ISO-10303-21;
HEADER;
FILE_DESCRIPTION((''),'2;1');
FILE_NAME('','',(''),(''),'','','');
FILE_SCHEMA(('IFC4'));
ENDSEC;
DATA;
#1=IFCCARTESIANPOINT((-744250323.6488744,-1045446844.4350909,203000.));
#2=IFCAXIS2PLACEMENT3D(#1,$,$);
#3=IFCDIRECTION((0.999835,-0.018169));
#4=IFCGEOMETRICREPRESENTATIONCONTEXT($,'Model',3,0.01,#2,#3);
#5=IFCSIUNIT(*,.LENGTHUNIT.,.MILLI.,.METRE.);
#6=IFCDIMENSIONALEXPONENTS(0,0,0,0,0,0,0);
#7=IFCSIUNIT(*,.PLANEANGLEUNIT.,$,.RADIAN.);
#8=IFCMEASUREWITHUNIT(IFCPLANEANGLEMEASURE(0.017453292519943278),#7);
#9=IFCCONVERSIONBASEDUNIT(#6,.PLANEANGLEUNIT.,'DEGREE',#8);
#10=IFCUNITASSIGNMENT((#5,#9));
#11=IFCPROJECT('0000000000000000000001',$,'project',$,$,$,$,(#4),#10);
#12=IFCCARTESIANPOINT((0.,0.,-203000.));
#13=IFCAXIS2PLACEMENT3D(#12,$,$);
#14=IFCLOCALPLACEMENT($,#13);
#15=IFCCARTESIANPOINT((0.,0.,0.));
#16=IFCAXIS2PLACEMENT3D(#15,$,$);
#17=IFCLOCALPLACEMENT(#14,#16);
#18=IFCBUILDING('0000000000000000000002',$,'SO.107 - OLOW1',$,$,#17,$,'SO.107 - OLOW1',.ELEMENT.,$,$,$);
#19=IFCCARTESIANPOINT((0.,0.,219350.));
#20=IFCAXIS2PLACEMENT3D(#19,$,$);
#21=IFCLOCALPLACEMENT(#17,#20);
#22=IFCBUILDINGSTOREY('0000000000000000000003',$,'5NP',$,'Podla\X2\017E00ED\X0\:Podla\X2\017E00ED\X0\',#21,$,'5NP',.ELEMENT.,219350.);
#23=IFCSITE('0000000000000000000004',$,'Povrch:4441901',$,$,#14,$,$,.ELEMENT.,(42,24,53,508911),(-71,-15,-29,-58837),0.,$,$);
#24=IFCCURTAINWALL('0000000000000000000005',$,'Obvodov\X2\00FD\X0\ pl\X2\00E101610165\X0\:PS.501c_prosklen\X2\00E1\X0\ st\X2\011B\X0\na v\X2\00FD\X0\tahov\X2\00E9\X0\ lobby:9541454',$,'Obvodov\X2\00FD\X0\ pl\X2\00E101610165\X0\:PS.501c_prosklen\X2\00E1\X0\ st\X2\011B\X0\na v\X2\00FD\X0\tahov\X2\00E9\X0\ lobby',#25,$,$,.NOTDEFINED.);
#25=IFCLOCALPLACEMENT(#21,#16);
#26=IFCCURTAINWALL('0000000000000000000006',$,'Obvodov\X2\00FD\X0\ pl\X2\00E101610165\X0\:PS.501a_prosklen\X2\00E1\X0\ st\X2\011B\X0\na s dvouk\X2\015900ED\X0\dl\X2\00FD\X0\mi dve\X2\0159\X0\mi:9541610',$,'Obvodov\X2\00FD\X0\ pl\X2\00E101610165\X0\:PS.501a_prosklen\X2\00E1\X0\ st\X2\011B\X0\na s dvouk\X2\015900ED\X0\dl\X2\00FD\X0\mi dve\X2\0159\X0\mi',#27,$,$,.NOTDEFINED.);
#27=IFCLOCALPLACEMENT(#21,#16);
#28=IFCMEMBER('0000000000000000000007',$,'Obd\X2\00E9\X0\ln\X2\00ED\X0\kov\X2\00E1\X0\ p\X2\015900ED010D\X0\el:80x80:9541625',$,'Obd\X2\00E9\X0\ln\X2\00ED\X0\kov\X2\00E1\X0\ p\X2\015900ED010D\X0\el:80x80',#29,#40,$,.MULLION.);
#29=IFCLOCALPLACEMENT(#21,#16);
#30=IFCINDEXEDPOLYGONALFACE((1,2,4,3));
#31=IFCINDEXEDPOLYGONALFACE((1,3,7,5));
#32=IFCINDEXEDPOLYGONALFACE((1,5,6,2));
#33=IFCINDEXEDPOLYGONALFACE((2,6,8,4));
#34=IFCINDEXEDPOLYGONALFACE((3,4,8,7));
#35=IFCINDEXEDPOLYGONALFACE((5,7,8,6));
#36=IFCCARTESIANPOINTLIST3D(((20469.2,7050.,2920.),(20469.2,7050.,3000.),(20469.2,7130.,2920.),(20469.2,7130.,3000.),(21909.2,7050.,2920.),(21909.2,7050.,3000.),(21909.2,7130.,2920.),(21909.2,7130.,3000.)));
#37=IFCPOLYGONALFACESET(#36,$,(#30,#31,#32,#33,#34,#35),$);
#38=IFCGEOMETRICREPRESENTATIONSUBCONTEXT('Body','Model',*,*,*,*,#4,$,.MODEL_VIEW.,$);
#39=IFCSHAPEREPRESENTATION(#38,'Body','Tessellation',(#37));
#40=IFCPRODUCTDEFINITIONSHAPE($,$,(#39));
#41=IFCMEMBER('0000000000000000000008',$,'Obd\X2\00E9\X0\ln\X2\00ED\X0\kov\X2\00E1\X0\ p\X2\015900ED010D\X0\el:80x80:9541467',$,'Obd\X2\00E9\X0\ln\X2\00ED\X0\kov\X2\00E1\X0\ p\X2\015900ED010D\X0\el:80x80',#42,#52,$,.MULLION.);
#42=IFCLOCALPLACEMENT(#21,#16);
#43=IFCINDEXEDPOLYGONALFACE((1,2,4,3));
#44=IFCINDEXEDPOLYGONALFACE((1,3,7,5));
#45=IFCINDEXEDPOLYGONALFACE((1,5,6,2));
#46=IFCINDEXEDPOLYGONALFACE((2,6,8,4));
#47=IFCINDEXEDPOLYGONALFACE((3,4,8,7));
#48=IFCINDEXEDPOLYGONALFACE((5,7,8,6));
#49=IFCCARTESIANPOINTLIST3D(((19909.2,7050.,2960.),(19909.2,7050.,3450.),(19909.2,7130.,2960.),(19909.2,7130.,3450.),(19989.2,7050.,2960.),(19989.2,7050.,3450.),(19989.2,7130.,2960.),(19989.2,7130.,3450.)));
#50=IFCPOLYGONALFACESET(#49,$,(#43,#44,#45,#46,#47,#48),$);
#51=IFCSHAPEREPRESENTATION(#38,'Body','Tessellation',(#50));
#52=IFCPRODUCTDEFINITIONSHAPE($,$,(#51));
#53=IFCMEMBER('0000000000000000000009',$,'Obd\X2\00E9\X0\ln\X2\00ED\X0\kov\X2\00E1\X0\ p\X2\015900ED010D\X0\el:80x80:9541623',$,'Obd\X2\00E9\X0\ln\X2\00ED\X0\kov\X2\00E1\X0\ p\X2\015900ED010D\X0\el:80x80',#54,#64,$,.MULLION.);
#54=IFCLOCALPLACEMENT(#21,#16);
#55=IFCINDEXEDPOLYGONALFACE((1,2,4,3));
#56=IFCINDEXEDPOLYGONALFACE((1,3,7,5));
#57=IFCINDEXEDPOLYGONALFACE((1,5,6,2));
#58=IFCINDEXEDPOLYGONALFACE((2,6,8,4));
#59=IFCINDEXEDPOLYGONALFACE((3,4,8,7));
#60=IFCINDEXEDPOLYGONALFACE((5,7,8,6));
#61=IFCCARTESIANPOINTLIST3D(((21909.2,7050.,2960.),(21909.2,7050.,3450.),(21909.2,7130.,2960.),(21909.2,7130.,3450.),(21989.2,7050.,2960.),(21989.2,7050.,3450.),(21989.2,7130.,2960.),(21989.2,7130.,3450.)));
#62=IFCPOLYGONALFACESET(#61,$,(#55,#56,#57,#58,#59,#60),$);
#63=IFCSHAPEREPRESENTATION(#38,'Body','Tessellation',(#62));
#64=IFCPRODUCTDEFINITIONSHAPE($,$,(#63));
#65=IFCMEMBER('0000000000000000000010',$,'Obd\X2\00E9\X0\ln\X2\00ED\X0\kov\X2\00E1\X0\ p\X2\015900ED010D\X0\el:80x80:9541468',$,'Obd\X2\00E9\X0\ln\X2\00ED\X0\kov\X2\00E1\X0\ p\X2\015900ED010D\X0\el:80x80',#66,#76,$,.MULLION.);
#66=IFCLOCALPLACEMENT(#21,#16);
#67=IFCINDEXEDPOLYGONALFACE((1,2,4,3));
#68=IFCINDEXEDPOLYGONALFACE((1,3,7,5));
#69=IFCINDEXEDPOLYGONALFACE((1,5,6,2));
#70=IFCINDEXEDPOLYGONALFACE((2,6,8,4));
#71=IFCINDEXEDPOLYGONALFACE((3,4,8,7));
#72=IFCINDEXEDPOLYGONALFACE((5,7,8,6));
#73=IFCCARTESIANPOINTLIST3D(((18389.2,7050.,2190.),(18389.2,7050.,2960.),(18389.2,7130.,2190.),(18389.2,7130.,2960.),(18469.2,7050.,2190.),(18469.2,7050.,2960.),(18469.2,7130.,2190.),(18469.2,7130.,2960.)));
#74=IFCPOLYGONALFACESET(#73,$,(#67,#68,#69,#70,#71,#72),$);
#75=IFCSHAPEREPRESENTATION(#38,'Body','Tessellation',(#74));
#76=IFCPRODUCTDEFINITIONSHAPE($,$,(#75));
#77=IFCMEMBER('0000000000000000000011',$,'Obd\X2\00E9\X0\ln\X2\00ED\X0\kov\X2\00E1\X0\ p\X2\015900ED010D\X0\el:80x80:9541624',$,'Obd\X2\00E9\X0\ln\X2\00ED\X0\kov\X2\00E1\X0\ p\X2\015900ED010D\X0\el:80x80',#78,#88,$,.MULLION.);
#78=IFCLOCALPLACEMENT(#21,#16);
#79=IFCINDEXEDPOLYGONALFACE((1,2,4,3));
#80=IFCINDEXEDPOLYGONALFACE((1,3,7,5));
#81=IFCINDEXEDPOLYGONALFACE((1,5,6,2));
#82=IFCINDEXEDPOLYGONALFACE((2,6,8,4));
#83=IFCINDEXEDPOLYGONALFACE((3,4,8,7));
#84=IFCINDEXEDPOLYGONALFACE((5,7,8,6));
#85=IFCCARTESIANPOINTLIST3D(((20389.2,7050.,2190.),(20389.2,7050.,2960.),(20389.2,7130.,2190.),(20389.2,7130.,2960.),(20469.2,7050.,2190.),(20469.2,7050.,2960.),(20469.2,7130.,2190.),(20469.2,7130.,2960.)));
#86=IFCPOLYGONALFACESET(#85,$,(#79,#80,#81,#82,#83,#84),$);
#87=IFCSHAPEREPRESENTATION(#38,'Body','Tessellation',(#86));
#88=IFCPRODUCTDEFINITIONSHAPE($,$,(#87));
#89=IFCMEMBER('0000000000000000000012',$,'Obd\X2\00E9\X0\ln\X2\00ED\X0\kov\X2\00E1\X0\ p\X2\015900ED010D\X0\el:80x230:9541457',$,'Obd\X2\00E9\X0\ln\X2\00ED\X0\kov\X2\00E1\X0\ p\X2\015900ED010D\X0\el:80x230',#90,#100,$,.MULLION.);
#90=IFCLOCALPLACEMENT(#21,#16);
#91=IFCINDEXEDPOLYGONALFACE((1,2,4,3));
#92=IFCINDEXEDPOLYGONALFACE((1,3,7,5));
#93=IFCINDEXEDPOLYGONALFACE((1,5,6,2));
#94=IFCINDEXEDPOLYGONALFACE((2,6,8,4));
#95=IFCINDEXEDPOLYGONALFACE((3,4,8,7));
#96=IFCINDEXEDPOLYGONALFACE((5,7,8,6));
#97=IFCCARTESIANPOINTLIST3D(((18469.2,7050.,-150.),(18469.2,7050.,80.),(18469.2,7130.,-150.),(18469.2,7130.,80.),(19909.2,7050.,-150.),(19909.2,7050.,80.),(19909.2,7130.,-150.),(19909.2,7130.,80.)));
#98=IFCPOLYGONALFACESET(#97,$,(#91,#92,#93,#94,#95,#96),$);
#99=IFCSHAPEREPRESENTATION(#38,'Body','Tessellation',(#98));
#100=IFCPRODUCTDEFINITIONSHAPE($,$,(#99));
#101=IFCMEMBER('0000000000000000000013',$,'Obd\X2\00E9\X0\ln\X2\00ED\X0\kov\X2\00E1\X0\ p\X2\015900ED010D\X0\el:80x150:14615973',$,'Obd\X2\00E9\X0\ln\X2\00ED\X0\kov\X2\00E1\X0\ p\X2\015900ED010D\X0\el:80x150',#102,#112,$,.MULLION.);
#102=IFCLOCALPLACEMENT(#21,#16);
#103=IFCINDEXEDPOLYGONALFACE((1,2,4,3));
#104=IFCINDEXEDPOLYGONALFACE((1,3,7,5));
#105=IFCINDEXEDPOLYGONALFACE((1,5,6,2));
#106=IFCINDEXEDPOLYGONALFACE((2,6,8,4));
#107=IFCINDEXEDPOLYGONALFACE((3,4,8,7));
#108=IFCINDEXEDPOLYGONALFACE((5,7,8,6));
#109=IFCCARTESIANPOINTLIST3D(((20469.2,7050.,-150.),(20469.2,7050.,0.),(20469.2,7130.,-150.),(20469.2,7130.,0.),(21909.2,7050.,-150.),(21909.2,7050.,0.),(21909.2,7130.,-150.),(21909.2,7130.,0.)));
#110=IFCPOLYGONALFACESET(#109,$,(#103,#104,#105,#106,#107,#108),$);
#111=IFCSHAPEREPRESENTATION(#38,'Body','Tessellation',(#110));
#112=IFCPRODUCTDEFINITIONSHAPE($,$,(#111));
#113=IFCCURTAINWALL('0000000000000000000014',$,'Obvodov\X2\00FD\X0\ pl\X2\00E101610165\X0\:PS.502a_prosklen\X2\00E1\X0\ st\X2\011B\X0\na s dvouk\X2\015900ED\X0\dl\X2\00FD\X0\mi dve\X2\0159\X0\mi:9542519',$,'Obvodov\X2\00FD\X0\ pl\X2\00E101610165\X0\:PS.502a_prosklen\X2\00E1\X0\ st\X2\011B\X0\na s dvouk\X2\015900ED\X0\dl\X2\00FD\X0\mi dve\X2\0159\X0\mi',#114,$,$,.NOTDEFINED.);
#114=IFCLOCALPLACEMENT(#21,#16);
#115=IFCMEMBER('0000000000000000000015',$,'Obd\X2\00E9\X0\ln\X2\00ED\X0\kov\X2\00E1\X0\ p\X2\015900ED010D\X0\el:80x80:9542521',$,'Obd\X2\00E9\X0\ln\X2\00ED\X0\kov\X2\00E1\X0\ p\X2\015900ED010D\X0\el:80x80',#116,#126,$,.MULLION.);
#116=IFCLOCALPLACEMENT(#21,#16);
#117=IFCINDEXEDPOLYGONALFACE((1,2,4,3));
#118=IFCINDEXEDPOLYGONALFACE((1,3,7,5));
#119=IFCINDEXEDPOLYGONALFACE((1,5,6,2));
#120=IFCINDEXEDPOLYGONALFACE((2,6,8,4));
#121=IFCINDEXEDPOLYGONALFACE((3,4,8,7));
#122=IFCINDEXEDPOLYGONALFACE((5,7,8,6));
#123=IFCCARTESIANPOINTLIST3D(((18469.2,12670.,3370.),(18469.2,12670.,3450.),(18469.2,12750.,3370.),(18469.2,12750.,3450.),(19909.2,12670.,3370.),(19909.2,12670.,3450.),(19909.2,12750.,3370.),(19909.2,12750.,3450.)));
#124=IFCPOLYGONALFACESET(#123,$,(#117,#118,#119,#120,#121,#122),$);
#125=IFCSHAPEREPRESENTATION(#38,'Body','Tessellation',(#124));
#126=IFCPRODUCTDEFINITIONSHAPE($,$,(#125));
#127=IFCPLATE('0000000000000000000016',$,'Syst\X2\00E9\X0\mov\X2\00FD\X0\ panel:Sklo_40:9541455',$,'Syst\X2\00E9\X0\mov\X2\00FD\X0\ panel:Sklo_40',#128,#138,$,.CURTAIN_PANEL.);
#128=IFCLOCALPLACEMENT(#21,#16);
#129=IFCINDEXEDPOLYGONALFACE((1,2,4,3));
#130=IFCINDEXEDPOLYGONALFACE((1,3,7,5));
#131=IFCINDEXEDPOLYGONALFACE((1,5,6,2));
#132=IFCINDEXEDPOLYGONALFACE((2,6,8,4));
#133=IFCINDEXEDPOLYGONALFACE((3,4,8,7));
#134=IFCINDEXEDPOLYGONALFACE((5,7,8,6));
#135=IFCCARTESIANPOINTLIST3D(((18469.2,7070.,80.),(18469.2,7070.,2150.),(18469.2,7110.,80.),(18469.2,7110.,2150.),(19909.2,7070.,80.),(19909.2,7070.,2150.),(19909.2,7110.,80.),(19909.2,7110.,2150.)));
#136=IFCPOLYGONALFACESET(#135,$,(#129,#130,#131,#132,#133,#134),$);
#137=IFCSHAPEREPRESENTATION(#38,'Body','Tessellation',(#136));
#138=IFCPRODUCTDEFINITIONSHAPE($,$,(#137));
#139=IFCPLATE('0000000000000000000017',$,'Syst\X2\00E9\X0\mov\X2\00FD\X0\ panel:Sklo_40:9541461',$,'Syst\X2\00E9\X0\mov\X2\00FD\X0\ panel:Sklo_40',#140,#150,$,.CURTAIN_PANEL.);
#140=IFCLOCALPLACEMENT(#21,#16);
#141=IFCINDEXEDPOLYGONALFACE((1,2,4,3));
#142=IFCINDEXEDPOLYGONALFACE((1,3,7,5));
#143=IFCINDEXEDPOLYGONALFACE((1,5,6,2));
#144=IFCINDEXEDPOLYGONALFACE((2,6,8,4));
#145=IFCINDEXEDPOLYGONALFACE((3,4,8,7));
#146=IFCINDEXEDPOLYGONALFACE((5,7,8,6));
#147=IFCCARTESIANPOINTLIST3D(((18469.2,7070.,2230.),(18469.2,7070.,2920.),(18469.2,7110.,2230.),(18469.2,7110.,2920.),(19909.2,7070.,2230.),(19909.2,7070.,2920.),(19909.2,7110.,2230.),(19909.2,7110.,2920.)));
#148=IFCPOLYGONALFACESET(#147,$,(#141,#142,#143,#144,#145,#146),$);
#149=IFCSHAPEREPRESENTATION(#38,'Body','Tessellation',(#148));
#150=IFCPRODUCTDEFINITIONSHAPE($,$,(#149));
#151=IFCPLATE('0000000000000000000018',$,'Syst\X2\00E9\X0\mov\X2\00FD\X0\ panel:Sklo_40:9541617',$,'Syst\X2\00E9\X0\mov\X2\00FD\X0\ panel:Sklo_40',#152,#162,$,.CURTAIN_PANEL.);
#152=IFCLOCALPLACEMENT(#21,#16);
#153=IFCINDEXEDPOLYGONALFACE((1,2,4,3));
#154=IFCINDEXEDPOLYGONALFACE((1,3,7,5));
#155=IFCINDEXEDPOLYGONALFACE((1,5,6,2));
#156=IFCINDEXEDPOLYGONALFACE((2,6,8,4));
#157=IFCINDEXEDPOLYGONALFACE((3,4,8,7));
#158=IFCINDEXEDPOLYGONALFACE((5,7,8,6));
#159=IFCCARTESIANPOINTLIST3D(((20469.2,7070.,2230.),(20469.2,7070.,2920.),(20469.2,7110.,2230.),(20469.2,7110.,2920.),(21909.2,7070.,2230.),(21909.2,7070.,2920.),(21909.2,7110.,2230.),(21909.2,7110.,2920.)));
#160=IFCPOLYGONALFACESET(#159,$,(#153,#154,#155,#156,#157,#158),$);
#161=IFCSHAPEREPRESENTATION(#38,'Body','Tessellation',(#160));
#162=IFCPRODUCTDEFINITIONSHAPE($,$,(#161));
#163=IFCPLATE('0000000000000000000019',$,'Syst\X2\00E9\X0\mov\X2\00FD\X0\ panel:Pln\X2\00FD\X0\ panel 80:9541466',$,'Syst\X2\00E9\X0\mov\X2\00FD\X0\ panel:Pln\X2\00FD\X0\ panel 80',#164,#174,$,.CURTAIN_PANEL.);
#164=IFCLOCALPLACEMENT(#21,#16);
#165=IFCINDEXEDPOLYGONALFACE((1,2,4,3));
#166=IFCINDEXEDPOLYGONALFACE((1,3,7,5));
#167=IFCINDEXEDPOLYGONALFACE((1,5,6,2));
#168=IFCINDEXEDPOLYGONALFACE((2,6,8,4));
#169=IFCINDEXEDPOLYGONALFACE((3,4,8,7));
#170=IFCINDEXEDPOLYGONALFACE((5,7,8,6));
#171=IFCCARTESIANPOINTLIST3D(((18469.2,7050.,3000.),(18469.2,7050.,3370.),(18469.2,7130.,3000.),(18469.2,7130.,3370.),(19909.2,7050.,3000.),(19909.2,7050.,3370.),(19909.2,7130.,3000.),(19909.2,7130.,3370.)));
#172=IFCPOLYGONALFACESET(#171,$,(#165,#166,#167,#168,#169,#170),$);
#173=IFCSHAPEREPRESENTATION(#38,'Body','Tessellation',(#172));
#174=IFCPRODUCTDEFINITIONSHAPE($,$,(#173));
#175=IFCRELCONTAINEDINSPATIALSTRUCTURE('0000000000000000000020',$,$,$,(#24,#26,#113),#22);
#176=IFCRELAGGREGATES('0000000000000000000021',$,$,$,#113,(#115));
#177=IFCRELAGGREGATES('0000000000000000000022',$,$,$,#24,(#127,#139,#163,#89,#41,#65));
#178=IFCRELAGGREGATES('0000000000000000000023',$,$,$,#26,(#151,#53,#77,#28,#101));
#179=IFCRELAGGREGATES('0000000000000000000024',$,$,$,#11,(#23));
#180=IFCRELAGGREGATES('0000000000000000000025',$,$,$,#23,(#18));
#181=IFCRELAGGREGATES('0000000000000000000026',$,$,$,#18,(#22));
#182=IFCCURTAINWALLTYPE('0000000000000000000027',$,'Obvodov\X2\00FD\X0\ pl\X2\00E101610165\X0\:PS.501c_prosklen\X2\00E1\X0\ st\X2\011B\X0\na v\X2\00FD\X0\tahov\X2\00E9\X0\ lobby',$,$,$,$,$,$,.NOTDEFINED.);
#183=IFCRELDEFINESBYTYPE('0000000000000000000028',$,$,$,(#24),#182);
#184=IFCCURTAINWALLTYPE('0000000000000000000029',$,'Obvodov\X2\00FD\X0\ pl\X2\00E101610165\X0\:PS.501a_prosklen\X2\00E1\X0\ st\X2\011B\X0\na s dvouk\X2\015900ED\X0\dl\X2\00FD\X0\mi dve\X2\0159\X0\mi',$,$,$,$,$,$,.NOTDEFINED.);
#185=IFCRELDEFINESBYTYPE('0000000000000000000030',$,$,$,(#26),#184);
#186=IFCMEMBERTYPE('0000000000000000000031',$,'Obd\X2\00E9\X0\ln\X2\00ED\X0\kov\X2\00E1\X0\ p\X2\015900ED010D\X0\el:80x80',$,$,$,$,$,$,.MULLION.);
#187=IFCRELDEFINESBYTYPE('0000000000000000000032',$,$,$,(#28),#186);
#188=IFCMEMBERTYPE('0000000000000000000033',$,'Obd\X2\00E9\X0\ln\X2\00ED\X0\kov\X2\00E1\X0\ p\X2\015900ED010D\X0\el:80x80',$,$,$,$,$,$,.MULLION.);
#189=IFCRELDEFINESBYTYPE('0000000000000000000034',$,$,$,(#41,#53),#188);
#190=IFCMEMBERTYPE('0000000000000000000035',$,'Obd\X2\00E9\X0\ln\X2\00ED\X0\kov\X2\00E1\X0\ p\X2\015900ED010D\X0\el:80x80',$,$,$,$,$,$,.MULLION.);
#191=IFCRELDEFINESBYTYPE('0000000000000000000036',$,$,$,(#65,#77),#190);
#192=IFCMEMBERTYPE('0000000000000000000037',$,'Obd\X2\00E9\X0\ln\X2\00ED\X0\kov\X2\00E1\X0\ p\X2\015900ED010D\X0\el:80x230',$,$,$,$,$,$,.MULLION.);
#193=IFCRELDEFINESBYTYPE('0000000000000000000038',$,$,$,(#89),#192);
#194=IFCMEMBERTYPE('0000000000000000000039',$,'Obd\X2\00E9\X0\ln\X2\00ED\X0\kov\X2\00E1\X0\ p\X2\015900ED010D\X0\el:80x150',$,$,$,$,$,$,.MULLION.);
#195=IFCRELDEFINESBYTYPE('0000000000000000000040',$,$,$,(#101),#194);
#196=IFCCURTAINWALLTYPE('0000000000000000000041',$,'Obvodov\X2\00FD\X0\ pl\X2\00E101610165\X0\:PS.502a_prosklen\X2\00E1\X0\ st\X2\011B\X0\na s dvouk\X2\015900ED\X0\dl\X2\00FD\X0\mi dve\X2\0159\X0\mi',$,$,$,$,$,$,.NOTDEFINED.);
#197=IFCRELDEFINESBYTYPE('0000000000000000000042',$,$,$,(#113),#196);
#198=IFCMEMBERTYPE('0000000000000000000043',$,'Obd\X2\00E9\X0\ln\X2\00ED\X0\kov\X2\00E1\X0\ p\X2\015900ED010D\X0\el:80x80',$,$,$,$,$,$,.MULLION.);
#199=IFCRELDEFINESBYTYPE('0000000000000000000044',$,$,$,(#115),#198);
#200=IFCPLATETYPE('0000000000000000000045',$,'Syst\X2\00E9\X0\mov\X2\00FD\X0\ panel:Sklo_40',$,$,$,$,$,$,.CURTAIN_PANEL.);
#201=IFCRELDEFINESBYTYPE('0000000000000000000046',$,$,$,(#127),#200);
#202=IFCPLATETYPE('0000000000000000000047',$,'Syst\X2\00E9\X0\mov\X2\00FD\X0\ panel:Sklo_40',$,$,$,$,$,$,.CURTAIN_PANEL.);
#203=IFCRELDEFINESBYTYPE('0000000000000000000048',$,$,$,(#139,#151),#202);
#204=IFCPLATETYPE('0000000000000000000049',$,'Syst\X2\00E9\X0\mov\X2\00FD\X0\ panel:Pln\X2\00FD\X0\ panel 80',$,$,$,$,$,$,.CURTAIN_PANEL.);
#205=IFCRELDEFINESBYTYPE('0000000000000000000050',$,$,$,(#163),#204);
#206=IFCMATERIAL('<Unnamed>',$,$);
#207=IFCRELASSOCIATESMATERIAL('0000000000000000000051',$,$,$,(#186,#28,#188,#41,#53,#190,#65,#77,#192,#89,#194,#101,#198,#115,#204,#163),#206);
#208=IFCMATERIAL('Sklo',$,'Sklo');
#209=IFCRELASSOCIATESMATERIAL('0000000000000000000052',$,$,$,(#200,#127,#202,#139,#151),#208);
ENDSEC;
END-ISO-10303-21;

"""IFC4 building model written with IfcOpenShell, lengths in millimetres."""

from ifc_helpers import new_model, entity, si_unit, converted_unit, direction, frame, origin, place, context, subcontext, project, spatial, indexed_curve, outline, extrude, source, transform, mapped, material, type_object, type_shapes, element, aggregate, save


model = new_model("IFC4")

# Units and contexts
model_context = context("Model", 3, precision=0.01, world=frame((-744250323.6488744, -1045446844.4350909, 203000.0)), true_north=direction((0.999835, -0.018169)))
body_context = subcontext(model_context, "Body", "Model", "MODEL_VIEW")
ifc_project = project(units=[si_unit("LENGTHUNIT", "METRE", prefix="MILLI"), converted_unit("PLANEANGLEUNIT", "DEGREE", entity("IfcPlaneAngleMeasure", 0.017453292519943278), si_unit("PLANEANGLEUNIT", "RADIAN"), dimensions=[0, 0, 0, 0, 0, 0, 0])], contexts=[model_context])

# Site, building, storey
site_placement = place(None, frame((0.0, 0.0, -203000.0)))
site = spatial("IfcSite", under=ifc_project, at=site_placement, Name="Povrch:4441901", CompositionType="ELEMENT", RefLatitude=(42, 24, 53, 508911), RefLongitude=(-71, -15, -29, -58837), RefElevation=0.0)
building_placement = place(site_placement, origin())
building = spatial("IfcBuilding", under=site, at=building_placement, Name="SO.107 - OLOW1", LongName="SO.107 - OLOW1", CompositionType="ELEMENT")
storey_placement = place(building_placement, frame((0.0, 0.0, 219350.0)))
storey = spatial("IfcBuildingStorey", under=building, at=storey_placement, Name="5NP", ObjectType="Podlaží:Podlaží", LongName="5NP", CompositionType="ELEMENT", Elevation=219350.0)

# Curtain walls
curtain_wall_type_1 = type_object("IfcCurtainWallType", Name="Obvodový plášť:PS.501c_prosklená stěna výtahové lobby", PredefinedType="NOTDEFINED")
curtain_wall_1_placement = place(storey_placement, frame((0.0, 0.0, -219350.0)))
curtain_wall_1 = element("IfcCurtainWall", 1, at=curtain_wall_1_placement, inside=storey, type_object=curtain_wall_type_1, Name="Obvodový plášť:PS.501c_prosklená stěna výtahové lobby:9541454", ObjectType="Obvodový plášť:PS.501c_prosklená stěna výtahové lobby", PredefinedType="NOTDEFINED")
ifc_material_1 = material(Name="<Unnamed>")
curtain_wall_type_2 = type_object("IfcCurtainWallType", Name="Obvodový plášť:PS.501a_prosklená stěna s dvoukřídlými dveřmi", PredefinedType="NOTDEFINED")
curtain_wall_2_placement = place(storey_placement, frame((0.0, 0.0, -219350.0)))
curtain_wall_2 = element("IfcCurtainWall", 2, at=curtain_wall_2_placement, inside=storey, type_object=curtain_wall_type_2, Name="Obvodový plášť:PS.501a_prosklená stěna s dvoukřídlými dveřmi:9541610", ObjectType="Obvodový plášť:PS.501a_prosklená stěna s dvoukřídlými dveřmi", PredefinedType="NOTDEFINED")

# Members
member_type_1 = type_object("IfcMemberType", Name="Obdélníková příčel:80x80", PredefinedType="MULLION", material=ifc_material_1)
shared_shape_1 = source(origin(), body_context, "Body", "SweptSolid", [
    extrude(outline(indexed_curve([(-40.0, -40.0), (40.0, -40.0), (40.0, 40.0), (-40.0, 40.0), (-40.0, -40.0)], self_intersect=False)), frame((0.0, 0.0, -1440.0), z_axis=(0.0, 0.0, 1.0), x_axis=(-1.0, 0.0, 0.0)), (0.0, 0.0, 1.0), 1440.0),
])
type_shapes(member_type_1, [shared_shape_1])
member_1_placement = place(curtain_wall_2_placement, frame((21909.2, 7090.0, 222310.0), z_axis=(1.0, 0.0, 0.0), x_axis=(0.0, 0.0, 1.0)))
member_1 = element("IfcMember", 3, at=member_1_placement, type_object=member_type_1, material=ifc_material_1, Name="Obdélníková příčel:80x80:9541625", ObjectType="Obdélníková příčel:80x80", PredefinedType="MULLION", context=body_context, shape_type="MappedRepresentation", body=[
    mapped(shared_shape_1, transform((0.0, 0.0, 0.0), scale=1.0)),
])
member_type_2 = type_object("IfcMemberType", Name="Obdélníková příčel:80x80", PredefinedType="MULLION", material=ifc_material_1)
shared_shape_2 = source(origin(), body_context, "Body", "SweptSolid", [
    extrude(outline(indexed_curve([(-40.0, -40.0), (40.0, -40.0), (40.0, 40.0), (-40.0, 40.0), (-40.0, -40.0)], self_intersect=False)), frame((-40.0, 0.0, -490.0), z_axis=(0.0, 0.0, 1.0), x_axis=(-1.0, 0.0, 0.0)), (0.0, 0.0, 1.0), 490.0),
])
type_shapes(member_type_2, [shared_shape_2])
member_2_placement = place(curtain_wall_1_placement, frame((19989.2, 7090.0, 222310.0), z_axis=(0.0, 0.0, -1.0), x_axis=(1.0, 0.0, 0.0)))
member_2 = element("IfcMember", 4, at=member_2_placement, type_object=member_type_2, material=ifc_material_1, Name="Obdélníková příčel:80x80:9541467", ObjectType="Obdélníková příčel:80x80", PredefinedType="MULLION", context=body_context, shape_type="MappedRepresentation", body=[
    mapped(shared_shape_2, transform((0.0, 0.0, 0.0), scale=1.0)),
])
member_3_placement = place(curtain_wall_2_placement, frame((21989.2, 7090.0, 222310.0), z_axis=(0.0, 0.0, -1.0), x_axis=(1.0, 0.0, 0.0)))
member_3 = element("IfcMember", 5, at=member_3_placement, type_object=member_type_2, material=ifc_material_1, Name="Obdélníková příčel:80x80:9541623", ObjectType="Obdélníková příčel:80x80", PredefinedType="MULLION", context=body_context, shape_type="MappedRepresentation", body=[
    mapped(shared_shape_2, transform((0.0, 0.0, 0.0), scale=1.0)),
])
member_type_3 = type_object("IfcMemberType", Name="Obdélníková příčel:80x80", PredefinedType="MULLION", material=ifc_material_1)
shared_shape_3 = source(origin(), body_context, "Body", "SweptSolid", [
    extrude(outline(indexed_curve([(-40.0, -40.0), (40.0, -40.0), (40.0, 40.0), (-40.0, 40.0), (-40.0, -40.0)], self_intersect=False)), frame((-40.0, 0.0, -770.0), z_axis=(0.0, 0.0, 1.0), x_axis=(-1.0, 0.0, 0.0)), (0.0, 0.0, 1.0), 770.0),
])
type_shapes(member_type_3, [shared_shape_3])
member_4_placement = place(curtain_wall_1_placement, frame((18389.2, 7090.0, 222310.0), z_axis=(0.0, 0.0, 1.0), x_axis=(-1.0, 0.0, 0.0)))
member_4 = element("IfcMember", 6, at=member_4_placement, type_object=member_type_3, material=ifc_material_1, Name="Obdélníková příčel:80x80:9541468", ObjectType="Obdélníková příčel:80x80", PredefinedType="MULLION", context=body_context, shape_type="MappedRepresentation", body=[
    mapped(shared_shape_3, transform((0.0, 0.0, 0.0), scale=1.0)),
])
member_5_placement = place(curtain_wall_2_placement, frame((20389.2, 7090.0, 222310.0), z_axis=(0.0, 0.0, 1.0), x_axis=(-1.0, 0.0, 0.0)))
member_5 = element("IfcMember", 7, at=member_5_placement, type_object=member_type_3, material=ifc_material_1, Name="Obdélníková příčel:80x80:9541624", ObjectType="Obdélníková příčel:80x80", PredefinedType="MULLION", context=body_context, shape_type="MappedRepresentation", body=[
    mapped(shared_shape_3, transform((0.0, 0.0, 0.0), scale=1.0)),
])
member_type_4 = type_object("IfcMemberType", Name="Obdélníková příčel:80x230", PredefinedType="MULLION", material=ifc_material_1)
shared_shape_4 = source(origin(), body_context, "Body", "SweptSolid", [
    extrude(outline(indexed_curve([(-115.0, -40.0), (115.0, -40.0), (115.0, 40.0), (-115.0, 40.0), (-115.0, -40.0)], self_intersect=False)), frame((-115.0, 0.0, -1440.0), z_axis=(0.0, 0.0, 1.0), x_axis=(-1.0, 0.0, 0.0)), (0.0, 0.0, 1.0), 1440.0),
])
type_shapes(member_type_4, [shared_shape_4])
member_6_placement = place(curtain_wall_1_placement, frame((18469.2, 7090.0, 219200.0), z_axis=(-1.0, 0.0, 0.0), x_axis=(0.0, 0.0, -1.0)))
member_6 = element("IfcMember", 8, at=member_6_placement, type_object=member_type_4, material=ifc_material_1, Name="Obdélníková příčel:80x230:9541457", ObjectType="Obdélníková příčel:80x230", PredefinedType="MULLION", context=body_context, shape_type="MappedRepresentation", body=[
    mapped(shared_shape_4, transform((0.0, 0.0, 0.0), scale=1.0)),
])
member_type_5 = type_object("IfcMemberType", Name="Obdélníková příčel:80x150", PredefinedType="MULLION", material=ifc_material_1)
shared_shape_5 = source(origin(), body_context, "Body", "SweptSolid", [
    extrude(outline(indexed_curve([(-75.0, -40.0), (75.0, -40.0), (75.0, 40.0), (-75.0, 40.0), (-75.0, -40.0)], self_intersect=False)), frame((-75.0, 0.0, -1440.0), z_axis=(0.0, 0.0, 1.0), x_axis=(-1.0, 0.0, 0.0)), (0.0, 0.0, 1.0), 1440.0),
])
type_shapes(member_type_5, [shared_shape_5])
member_7_placement = place(curtain_wall_2_placement, frame((20469.2, 7090.0, 219200.0), z_axis=(-1.0, 0.0, 0.0), x_axis=(0.0, 0.0, -1.0)))
member_7 = element("IfcMember", 9, at=member_7_placement, type_object=member_type_5, material=ifc_material_1, Name="Obdélníková příčel:80x150:14615973", ObjectType="Obdélníková příčel:80x150", PredefinedType="MULLION", context=body_context, shape_type="MappedRepresentation", body=[
    mapped(shared_shape_5, transform((0.0, 0.0, 0.0), scale=1.0)),
])

# Curtain wall, member
curtain_wall_type_3 = type_object("IfcCurtainWallType", Name="Obvodový plášť:PS.502a_prosklená stěna s dvoukřídlými dveřmi", PredefinedType="NOTDEFINED")
curtain_wall_3_placement = place(storey_placement, frame((0.0, 0.0, -219350.0)))
curtain_wall_3 = element("IfcCurtainWall", 10, at=curtain_wall_3_placement, inside=storey, type_object=curtain_wall_type_3, Name="Obvodový plášť:PS.502a_prosklená stěna s dvoukřídlými dveřmi:9542519", ObjectType="Obvodový plášť:PS.502a_prosklená stěna s dvoukřídlými dveřmi", PredefinedType="NOTDEFINED")
member_type_6 = type_object("IfcMemberType", Name="Obdélníková příčel:80x80", PredefinedType="MULLION", material=ifc_material_1)
shared_shape_6 = source(origin(), body_context, "Body", "SweptSolid", [
    extrude(outline(indexed_curve([(-40.0, -40.0), (40.0, -40.0), (40.0, 40.0), (-40.0, 40.0), (-40.0, -40.0)], self_intersect=False)), frame((-40.0, 0.0, -1440.0), z_axis=(0.0, 0.0, 1.0), x_axis=(-1.0, 0.0, 0.0)), (0.0, 0.0, 1.0), 1440.0),
])
type_shapes(member_type_6, [shared_shape_6])
member_8_placement = place(curtain_wall_3_placement, frame((19909.2, 12710.0, 222800.0), z_axis=(1.0, 0.0, 0.0), x_axis=(0.0, 0.0, 1.0)))
member_8 = element("IfcMember", 11, at=member_8_placement, type_object=member_type_6, material=ifc_material_1, Name="Obdélníková příčel:80x80:9542521", ObjectType="Obdélníková příčel:80x80", PredefinedType="MULLION", context=body_context, shape_type="MappedRepresentation", body=[
    mapped(shared_shape_6, transform((0.0, 0.0, 0.0), scale=1.0)),
])
aggregate(curtain_wall_3, [member_8])

# Plates
ifc_material_2 = material(Name="Sklo", Category="Sklo")
plate_type_1 = type_object("IfcPlateType", Name="Systémový panel:Sklo_40", PredefinedType="CURTAIN_PANEL", material=ifc_material_2)
shared_shape_7 = source(origin(), body_context, "Body", "SweptSolid", [
    extrude(outline(indexed_curve([(-20.0, -720.0), (20.0, -720.0), (20.0, 720.0), (-20.0, 720.0), (-20.0, -720.0)], self_intersect=False)), frame((0.0, 0.0, 0.0), z_axis=(0.0, 0.0, 1.0), x_axis=(0.0, 1.0, 0.0)), (0.0, 0.0, 1.0), 2070.0),
])
type_shapes(plate_type_1, [shared_shape_7])
plate_1_placement = place(curtain_wall_1_placement, frame((19189.2, 7090.0, 219430.0)))
plate_1 = element("IfcPlate", 12, at=plate_1_placement, type_object=plate_type_1, material=ifc_material_2, Name="Systémový panel:Sklo_40:9541455", ObjectType="Systémový panel:Sklo_40", PredefinedType="CURTAIN_PANEL", context=body_context, shape_type="MappedRepresentation", body=[
    mapped(shared_shape_7, transform((0.0, 0.0, 0.0), scale=1.0)),
])
plate_type_2 = type_object("IfcPlateType", Name="Systémový panel:Sklo_40", PredefinedType="CURTAIN_PANEL", material=ifc_material_2)
shared_shape_8 = source(origin(), body_context, "Body", "SweptSolid", [
    extrude(outline(indexed_curve([(-20.0, -720.0), (20.0, -720.0), (20.0, 720.0), (-20.0, 720.0), (-20.0, -720.0)], self_intersect=False)), frame((0.0, 0.0, 0.0), z_axis=(0.0, 0.0, 1.0), x_axis=(0.0, 1.0, 0.0)), (0.0, 0.0, 1.0), 690.0),
])
type_shapes(plate_type_2, [shared_shape_8])
plate_2_placement = place(curtain_wall_1_placement, frame((19189.2, 7090.0, 221580.0)))
plate_2 = element("IfcPlate", 13, at=plate_2_placement, type_object=plate_type_2, material=ifc_material_2, Name="Systémový panel:Sklo_40:9541461", ObjectType="Systémový panel:Sklo_40", PredefinedType="CURTAIN_PANEL", context=body_context, shape_type="MappedRepresentation", body=[
    mapped(shared_shape_8, transform((0.0, 0.0, 0.0), scale=1.0)),
])
plate_3_placement = place(curtain_wall_2_placement, frame((21189.2, 7090.0, 221580.0)))
plate_3 = element("IfcPlate", 14, at=plate_3_placement, type_object=plate_type_2, material=ifc_material_2, Name="Systémový panel:Sklo_40:9541617", ObjectType="Systémový panel:Sklo_40", PredefinedType="CURTAIN_PANEL", context=body_context, shape_type="MappedRepresentation", body=[
    mapped(shared_shape_8, transform((0.0, 0.0, 0.0), scale=1.0)),
])
plate_type_3 = type_object("IfcPlateType", Name="Systémový panel:Plný panel 80", PredefinedType="CURTAIN_PANEL", material=ifc_material_1)
shared_shape_9 = source(origin(), body_context, "Body", "SweptSolid", [
    extrude(outline(indexed_curve([(-40.0, -720.0), (40.0, -720.0), (40.0, 720.0), (-40.0, 720.0), (-40.0, -720.0)], self_intersect=False)), frame((0.0, 0.0, 0.0), z_axis=(0.0, 0.0, 1.0), x_axis=(0.0, 1.0, 0.0)), (0.0, 0.0, 1.0), 370.0),
])
type_shapes(plate_type_3, [shared_shape_9])
plate_4_placement = place(curtain_wall_1_placement, frame((19189.2, 7090.0, 222350.0)))
plate_4 = element("IfcPlate", 15, at=plate_4_placement, type_object=plate_type_3, material=ifc_material_1, Name="Systémový panel:Plný panel 80:9541466", ObjectType="Systémový panel:Plný panel 80", PredefinedType="CURTAIN_PANEL", context=body_context, shape_type="MappedRepresentation", body=[
    mapped(shared_shape_9, transform((0.0, 0.0, 0.0), scale=1.0)),
])
aggregate(curtain_wall_1, [plate_1, plate_2, plate_4, member_6, member_2, member_4])

aggregate(curtain_wall_2, [plate_3, member_3, member_5, member_1, member_7])

save(model, "model.ifc")
